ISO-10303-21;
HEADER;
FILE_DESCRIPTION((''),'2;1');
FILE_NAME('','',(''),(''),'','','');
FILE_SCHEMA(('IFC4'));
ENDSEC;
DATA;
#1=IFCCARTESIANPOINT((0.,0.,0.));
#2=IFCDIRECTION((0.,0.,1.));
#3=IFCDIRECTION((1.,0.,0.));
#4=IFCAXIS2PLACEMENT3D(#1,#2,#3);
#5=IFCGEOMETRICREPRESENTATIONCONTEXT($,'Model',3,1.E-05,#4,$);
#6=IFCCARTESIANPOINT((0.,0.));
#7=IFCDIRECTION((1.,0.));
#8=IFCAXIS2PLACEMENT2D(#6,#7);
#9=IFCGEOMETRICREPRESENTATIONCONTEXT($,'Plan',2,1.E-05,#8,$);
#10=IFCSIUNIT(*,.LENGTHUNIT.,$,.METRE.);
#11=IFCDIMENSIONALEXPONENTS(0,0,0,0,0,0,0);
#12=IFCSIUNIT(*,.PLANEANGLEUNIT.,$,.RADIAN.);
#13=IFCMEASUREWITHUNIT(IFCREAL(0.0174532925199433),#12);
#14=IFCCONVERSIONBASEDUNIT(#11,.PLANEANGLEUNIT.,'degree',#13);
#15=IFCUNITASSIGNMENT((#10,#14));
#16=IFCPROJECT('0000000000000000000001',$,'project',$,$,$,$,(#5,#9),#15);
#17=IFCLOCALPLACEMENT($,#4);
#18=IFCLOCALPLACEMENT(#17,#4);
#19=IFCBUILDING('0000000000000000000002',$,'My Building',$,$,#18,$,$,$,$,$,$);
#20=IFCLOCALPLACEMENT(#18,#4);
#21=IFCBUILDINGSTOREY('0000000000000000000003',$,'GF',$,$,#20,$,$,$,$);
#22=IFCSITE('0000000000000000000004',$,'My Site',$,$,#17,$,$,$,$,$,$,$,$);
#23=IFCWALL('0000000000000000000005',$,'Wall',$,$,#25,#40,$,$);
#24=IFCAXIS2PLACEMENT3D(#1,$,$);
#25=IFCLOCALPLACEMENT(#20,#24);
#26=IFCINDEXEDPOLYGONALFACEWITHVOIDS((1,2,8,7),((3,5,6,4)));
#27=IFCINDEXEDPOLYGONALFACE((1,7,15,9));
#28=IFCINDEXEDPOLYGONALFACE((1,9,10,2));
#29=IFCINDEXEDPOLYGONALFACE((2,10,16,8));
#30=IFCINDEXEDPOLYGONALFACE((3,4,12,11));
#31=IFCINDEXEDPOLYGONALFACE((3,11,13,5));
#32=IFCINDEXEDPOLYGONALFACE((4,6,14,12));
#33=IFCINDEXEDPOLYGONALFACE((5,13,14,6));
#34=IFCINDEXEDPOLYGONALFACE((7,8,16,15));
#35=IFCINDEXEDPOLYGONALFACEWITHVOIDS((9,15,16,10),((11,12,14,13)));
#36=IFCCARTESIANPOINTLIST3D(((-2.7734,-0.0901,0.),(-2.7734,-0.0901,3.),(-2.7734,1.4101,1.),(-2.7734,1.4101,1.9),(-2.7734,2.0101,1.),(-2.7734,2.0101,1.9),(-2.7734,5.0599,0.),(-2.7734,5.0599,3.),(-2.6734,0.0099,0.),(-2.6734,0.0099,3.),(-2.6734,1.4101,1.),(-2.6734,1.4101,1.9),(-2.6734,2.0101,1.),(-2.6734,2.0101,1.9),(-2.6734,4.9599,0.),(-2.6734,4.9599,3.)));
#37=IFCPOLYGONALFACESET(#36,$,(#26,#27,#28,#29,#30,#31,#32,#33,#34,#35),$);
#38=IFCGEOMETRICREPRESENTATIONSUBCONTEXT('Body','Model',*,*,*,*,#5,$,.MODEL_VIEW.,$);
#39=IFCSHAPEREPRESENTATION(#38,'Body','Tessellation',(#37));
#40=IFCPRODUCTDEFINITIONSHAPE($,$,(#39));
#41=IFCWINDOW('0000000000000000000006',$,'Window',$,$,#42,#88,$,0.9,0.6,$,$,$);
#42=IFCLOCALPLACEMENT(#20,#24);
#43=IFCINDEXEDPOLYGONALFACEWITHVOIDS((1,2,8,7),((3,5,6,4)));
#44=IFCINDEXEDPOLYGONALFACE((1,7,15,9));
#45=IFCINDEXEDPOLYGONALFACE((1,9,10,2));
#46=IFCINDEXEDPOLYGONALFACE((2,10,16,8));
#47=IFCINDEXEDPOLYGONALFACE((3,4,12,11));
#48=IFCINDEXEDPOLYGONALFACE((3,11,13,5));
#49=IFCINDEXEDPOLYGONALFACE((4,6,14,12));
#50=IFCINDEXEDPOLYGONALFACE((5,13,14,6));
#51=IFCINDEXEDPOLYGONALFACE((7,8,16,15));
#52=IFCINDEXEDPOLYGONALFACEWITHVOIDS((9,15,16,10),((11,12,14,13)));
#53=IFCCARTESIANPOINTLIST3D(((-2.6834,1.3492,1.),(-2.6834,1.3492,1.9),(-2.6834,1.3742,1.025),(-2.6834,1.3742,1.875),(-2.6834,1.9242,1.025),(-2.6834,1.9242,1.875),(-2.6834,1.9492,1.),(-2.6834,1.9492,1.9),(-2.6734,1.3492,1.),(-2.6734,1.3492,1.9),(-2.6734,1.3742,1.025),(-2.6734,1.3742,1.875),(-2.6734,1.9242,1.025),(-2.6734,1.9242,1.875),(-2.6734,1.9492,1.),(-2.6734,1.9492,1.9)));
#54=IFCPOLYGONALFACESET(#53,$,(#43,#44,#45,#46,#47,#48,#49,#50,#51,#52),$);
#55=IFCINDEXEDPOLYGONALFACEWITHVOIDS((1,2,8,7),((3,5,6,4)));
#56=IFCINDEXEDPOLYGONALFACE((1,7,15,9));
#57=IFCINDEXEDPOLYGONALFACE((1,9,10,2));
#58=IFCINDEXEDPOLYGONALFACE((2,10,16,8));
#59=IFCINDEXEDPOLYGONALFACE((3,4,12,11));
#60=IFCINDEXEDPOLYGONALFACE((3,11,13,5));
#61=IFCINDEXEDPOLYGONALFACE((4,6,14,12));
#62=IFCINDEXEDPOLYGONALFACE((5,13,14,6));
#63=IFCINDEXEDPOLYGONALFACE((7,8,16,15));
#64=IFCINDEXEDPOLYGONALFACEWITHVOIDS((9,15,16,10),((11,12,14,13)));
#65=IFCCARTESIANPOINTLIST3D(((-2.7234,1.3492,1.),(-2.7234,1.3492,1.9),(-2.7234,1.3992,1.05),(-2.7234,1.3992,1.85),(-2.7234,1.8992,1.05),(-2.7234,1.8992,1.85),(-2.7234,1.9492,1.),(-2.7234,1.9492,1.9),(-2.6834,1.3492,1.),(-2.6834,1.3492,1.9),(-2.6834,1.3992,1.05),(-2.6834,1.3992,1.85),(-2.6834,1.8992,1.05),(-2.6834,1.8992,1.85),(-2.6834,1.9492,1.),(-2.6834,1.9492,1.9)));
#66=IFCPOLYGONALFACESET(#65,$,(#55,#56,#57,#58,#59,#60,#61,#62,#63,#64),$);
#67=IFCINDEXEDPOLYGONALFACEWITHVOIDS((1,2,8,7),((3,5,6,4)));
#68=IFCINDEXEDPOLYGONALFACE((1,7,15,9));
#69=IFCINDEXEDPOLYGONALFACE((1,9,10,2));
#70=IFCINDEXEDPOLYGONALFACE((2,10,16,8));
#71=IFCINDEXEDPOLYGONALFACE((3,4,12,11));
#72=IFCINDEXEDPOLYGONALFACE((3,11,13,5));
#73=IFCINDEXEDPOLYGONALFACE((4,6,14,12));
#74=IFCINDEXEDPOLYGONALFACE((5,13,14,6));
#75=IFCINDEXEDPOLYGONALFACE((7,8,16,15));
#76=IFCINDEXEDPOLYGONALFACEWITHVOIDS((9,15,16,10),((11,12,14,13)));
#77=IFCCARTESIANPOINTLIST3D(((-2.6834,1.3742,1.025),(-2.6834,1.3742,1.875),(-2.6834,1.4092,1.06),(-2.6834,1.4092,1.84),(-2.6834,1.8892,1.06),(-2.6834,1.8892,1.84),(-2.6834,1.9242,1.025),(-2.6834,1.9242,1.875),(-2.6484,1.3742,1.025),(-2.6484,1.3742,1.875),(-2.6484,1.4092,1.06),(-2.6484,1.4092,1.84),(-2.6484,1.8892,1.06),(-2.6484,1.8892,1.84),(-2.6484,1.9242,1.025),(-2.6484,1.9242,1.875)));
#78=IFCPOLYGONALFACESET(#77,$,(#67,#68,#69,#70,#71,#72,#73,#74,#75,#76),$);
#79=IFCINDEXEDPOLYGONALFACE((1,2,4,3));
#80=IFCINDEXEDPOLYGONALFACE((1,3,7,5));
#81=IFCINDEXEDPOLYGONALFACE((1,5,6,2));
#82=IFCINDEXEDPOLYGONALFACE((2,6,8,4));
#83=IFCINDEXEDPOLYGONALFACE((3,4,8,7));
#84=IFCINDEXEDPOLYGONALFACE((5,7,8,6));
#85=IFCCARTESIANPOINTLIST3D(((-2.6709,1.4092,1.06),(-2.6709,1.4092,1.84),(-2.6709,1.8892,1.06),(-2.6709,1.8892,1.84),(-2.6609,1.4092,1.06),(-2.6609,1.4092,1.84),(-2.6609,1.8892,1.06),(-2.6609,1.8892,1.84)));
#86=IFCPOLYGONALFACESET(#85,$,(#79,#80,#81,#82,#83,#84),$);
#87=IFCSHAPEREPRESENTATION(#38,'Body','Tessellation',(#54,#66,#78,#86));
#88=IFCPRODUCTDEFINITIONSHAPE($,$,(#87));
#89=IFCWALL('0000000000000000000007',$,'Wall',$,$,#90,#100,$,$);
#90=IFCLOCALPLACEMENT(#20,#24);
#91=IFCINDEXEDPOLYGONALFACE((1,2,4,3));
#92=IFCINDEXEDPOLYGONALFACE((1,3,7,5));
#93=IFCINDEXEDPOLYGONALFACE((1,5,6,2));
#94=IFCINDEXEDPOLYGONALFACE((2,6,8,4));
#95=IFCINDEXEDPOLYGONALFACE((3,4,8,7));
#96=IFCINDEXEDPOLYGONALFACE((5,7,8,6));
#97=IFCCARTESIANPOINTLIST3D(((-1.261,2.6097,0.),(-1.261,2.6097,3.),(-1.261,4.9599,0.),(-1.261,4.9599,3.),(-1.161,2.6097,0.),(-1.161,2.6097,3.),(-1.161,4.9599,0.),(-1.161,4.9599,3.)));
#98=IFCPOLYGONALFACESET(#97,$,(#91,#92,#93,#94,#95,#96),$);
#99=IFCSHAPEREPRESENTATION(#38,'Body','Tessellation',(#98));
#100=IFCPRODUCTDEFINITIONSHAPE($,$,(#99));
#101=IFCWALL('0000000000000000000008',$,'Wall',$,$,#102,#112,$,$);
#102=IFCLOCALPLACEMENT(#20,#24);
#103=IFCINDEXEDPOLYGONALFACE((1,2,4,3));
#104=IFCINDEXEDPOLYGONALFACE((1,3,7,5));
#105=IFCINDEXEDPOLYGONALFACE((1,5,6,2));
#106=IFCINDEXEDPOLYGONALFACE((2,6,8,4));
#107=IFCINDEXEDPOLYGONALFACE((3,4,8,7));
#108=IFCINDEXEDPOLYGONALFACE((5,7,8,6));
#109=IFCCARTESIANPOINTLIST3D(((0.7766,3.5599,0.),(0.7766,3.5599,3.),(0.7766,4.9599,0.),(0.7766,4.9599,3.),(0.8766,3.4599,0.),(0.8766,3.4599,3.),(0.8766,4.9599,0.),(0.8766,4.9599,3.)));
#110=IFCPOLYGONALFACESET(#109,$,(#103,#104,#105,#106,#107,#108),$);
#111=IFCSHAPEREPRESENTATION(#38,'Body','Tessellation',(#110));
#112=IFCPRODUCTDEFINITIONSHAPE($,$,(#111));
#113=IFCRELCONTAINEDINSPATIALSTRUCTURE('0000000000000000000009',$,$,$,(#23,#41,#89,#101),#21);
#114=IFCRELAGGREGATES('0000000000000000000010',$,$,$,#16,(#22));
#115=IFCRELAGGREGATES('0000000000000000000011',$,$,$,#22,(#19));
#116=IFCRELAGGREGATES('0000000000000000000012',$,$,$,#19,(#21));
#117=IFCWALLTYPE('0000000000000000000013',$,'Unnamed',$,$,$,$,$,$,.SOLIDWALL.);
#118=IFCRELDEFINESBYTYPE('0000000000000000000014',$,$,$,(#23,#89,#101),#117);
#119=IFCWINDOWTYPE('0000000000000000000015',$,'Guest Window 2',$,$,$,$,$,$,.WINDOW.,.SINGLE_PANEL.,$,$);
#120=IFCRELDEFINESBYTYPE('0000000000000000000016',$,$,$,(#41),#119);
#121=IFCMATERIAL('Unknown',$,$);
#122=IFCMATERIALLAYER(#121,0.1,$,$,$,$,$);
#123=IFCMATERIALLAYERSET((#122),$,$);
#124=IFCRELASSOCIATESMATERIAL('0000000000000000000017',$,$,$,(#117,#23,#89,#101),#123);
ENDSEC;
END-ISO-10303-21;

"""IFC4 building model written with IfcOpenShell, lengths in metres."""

from ifc_helpers import new_model, entity, si_unit, converted_unit, frame, origin_with_axes, origin_2d_with_axis, place, context, subcontext, project, spatial, line, indexed_curve, outline, extrude, shape, source, transform, mapped, material, layer, layer_set, layer_usage, type_object, type_shapes, element, fill, save


model = new_model("IFC4")

# Units and contexts
model_context = context("Model", 3, precision=1e-05, world=origin_with_axes())
plan_context = context("Plan", 2, precision=1e-05, world=origin_2d_with_axis())
body_context_1 = subcontext(model_context, "Body", "Model", "MODEL_VIEW")
body_context_2 = subcontext(plan_context, "Body", "Plan", "PLAN_VIEW")
ifc_project = project(units=[si_unit("LENGTHUNIT", "METRE"), converted_unit("PLANEANGLEUNIT", "degree", entity("IfcReal", 0.0174532925199433), si_unit("PLANEANGLEUNIT", "RADIAN"), dimensions=[0, 0, 0, 0, 0, 0, 0])], contexts=[model_context, plan_context])

# Site, building, storey
site_placement = place(None, origin_with_axes())
site = spatial("IfcSite", under=ifc_project, at=site_placement, Name="My Site")
building_placement = place(site_placement, origin_with_axes())
building = spatial("IfcBuilding", under=site, at=building_placement, Name="My Building")
storey_placement = place(building_placement, origin_with_axes())
storey = spatial("IfcBuildingStorey", under=building, at=storey_placement, Name="GF")

# Shared definitions
ifc_material_1 = material(Name="Unknown")

# Shared definitions
ifc_layer_1 = layer(ifc_material_1, 0.1)
ifc_layer_set_1 = layer_set([ifc_layer_1])
wall_type = type_object("IfcWallType", Name="Unnamed", PredefinedType="SOLIDWALL", material=ifc_layer_set_1)

# Wall, opening, window
ifc_layer_usage_1 = layer_usage(ifc_layer_set_1, "AXIS2", "POSITIVE", 0.0)
wall_1_placement = place(storey_placement, frame((-2.7734, 5.0599, 0.0), z_axis=(0.0, 0.0, 1.0), x_axis=(0.0, -1.0, 0.0)))
wall_1 = element("IfcWall", 1, at=wall_1_placement, inside=storey, type_object=wall_type, material=ifc_layer_usage_1, Name="Wall", context=body_context_1, shape_type="SweptSolid", body=[
    extrude(outline(indexed_curve([(0.0, 0.0), (0.1, 0.1), (5.05, 0.1), (5.15, 0.0)], segments=[line(1, 2, 3, 4, 1)])), origin_with_axes(), (0.0, 0.0, 1.0), 3.0),
])
shared_shape_1 = source(origin_with_axes(), body_context_1, "Body", "SweptSolid", [
    extrude(outline(indexed_curve([(0.0, 0.0), (0.6, 0.0), (0.6, 0.9), (0.0, 0.9)], segments=[line(1, 2, 3, 4, 1)])), frame((0.0, -0.6, 0.0), z_axis=(0.0, -1.0, 0.0), x_axis=(1.0, 0.0, 0.0)), (0.0, 0.0, -1.0), 1.2),
])
opening_1_placement = place(wall_1_placement, frame((3.0498, 0.0, 1.0), z_axis=(0.0, 0.0, 1.0), x_axis=(1.0, 0.0, 0.0)))
opening_1 = element("IfcOpeningElement", 2, at=opening_1_placement, cuts=wall_1, PredefinedType="OPENING", context=body_context_1, shape_type="MappedRepresentation", body=[
    mapped(shared_shape_1, transform((0.0, 0.0, 0.0), x_axis=(1.0, 0.0, 0.0), y_axis=(0.0, 1.0, 0.0), z_axis=(0.0, 0.0, 1.0), scale=1.0)),
])
window_type_1 = type_object("IfcWindowType", Name="Guest Window 2", PartitioningType="SINGLE_PANEL", PredefinedType="WINDOW")
shared_shape_2 = source(origin_with_axes(), body_context_1, "Body", "SweptSolid", [
    extrude(outline(indexed_curve([(0.0, 0.0), (0.6, 0.0), (0.6, 0.9), (0.0, 0.9)], segments=[line(1, 2, 3, 4, 1)]), holes=[indexed_curve([(0.025, 0.025), (0.575, 0.025), (0.575, 0.875), (0.025, 0.875)], segments=[line(1, 2, 3, 4, 1)])]), frame((0.0, 0.09, 0.0), z_axis=(0.0, -1.0, 0.0), x_axis=(1.0, 0.0, 0.0)), (0.0, 0.0, -1.0), 0.01),
    extrude(outline(indexed_curve([(0.0, 0.0), (0.6, 0.0), (0.6, 0.9), (0.0, 0.9)], segments=[line(1, 2, 3, 4, 1)]), holes=[indexed_curve([(0.05, 0.05), (0.55, 0.05), (0.55, 0.85), (0.05, 0.85)], segments=[line(1, 2, 3, 4, 1)])]), frame((0.0, 0.05, 0.0), z_axis=(0.0, -1.0, 0.0), x_axis=(1.0, 0.0, 0.0)), (0.0, 0.0, -1.0), 0.04),
    extrude(outline(indexed_curve([(0.0, 0.0), (0.55, 0.0), (0.55, 0.85), (0.0, 0.85)], segments=[line(1, 2, 3, 4, 1)]), holes=[indexed_curve([(0.035, 0.035), (0.515, 0.035), (0.515, 0.815), (0.035, 0.815)], segments=[line(1, 2, 3, 4, 1)])]), frame((0.025, 0.09, 0.025), z_axis=(0.0, -1.0, 0.0), x_axis=(1.0, 0.0, 0.0)), (0.0, 0.0, -1.0), 0.035),
    extrude(outline(indexed_curve([(0.035, 0.035), (0.515, 0.035), (0.515, 0.815), (0.035, 0.815)], segments=[line(1, 2, 3, 4, 1)])), frame((0.025, 0.1025, 0.025), z_axis=(0.0, -1.0, 0.0), x_axis=(1.0, 0.0, 0.0)), (0.0, 0.0, -1.0), 0.01),
])
shared_shape_3 = source(origin_with_axes(), body_context_2, "Body", "Curve2D", [
    entity("IfcIndexedPolyCurve", entity("IfcCartesianPointList2D", [[0.05, 0.05], [0.55, 0.05]])),
    entity("IfcIndexedPolyCurve", entity("IfcCartesianPointList2D", [[0.0, 0.1], [0.025, 0.1], [0.025, 0.09], [0.05, 0.09], [0.05, 0.05], [0.0, 0.05]]), [entity("IfcLineIndex", [1, 2, 3, 4, 5, 6, 1])]),
    entity("IfcIndexedPolyCurve", entity("IfcCartesianPointList2D", [[0.6, 0.1], [0.575, 0.1], [0.575, 0.09], [0.55, 0.09], [0.55, 0.05], [0.6, 0.05]]), [entity("IfcLineIndex", [1, 2, 3, 4, 5, 6, 1])]),
    entity("IfcIndexedPolyCurve", entity("IfcCartesianPointList2D", [[0.025, 0.09], [0.06, 0.09], [0.06, 0.125], [0.025, 0.125]]), [entity("IfcLineIndex", [1, 2, 3, 4, 1])]),
    entity("IfcIndexedPolyCurve", entity("IfcCartesianPointList2D", [[0.575, 0.09], [0.54, 0.09], [0.54, 0.125], [0.575, 0.125]]), [entity("IfcLineIndex", [1, 2, 3, 4, 1])]),
    entity("IfcIndexedPolyCurve", entity("IfcCartesianPointList2D", [[0.06, 0.09], [0.54, 0.09]])),
    entity("IfcIndexedPolyCurve", entity("IfcCartesianPointList2D", [[0.06, 0.125], [0.54, 0.125]])),
    entity("IfcIndexedPolyCurve", entity("IfcCartesianPointList2D", [[0.06, 0.1075], [0.54, 0.1075]])),
])
type_shapes(window_type_1, [shared_shape_2, shared_shape_3])
window_1_placement = place(opening_1_placement, frame((0.061, 0.0, 0.0), z_axis=(0.0, 0.0, 1.0), x_axis=(1.0, 0.0, 0.0)))
window_1 = element("IfcWindow", 3, at=window_1_placement, inside=storey, type_object=window_type_1, Name="Window", OverallHeight=0.9, OverallWidth=0.6, shapes=[
    shape(body_context_1, "Body", "MappedRepresentation", [mapped(shared_shape_2, transform((0.0, 0.0, 0.0), x_axis=(1.0, 0.0, 0.0), y_axis=(0.0, 1.0, 0.0), z_axis=(0.0, 0.0, 1.0), scale=1.0))]),
    shape(body_context_2, "Body", "MappedRepresentation", [mapped(shared_shape_3, transform((0.0, 0.0, 0.0), x_axis=(1.0, 0.0, 0.0), y_axis=(0.0, 1.0, 0.0), z_axis=(0.0, 0.0, 1.0), scale=1.0))]),
])
fill(opening_1, window_1)

# Walls
ifc_layer_usage_2 = layer_usage(ifc_layer_set_1, "AXIS2", "POSITIVE", 0.0)
wall_2_placement = place(storey_placement, frame((-1.261, 4.9599, 0.0), z_axis=(0.0, 0.0, 1.0), x_axis=(0.000037, -1.0, 0.0)))
element("IfcWall", 4, at=wall_2_placement, inside=storey, type_object=wall_type, material=ifc_layer_usage_2, Name="Wall", context=body_context_1, shape_type="SweptSolid", body=[
    extrude(outline(indexed_curve([(0.0, 0.0), (0.0, 0.1), (2.3502, 0.1), (2.3502, 0.0)], segments=[line(1, 2, 3, 4, 1)])), origin_with_axes(), (0.0, 0.0, 1.0), 3.0),
])
ifc_layer_usage_3 = layer_usage(ifc_layer_set_1, "AXIS2", "POSITIVE", 0.0)
wall_3_placement = place(storey_placement, frame((0.7766, 4.9599, 0.0), z_axis=(0.0, 0.0, 1.0), x_axis=(0.0, -1.0, 0.0)))
element("IfcWall", 5, at=wall_3_placement, inside=storey, type_object=wall_type, material=ifc_layer_usage_3, Name="Wall", context=body_context_1, shape_type="SweptSolid", body=[
    extrude(outline(indexed_curve([(0.0, 0.0), (0.0, 0.1), (1.5, 0.1), (1.4, 0.0)], segments=[line(1, 2, 3, 4, 1)])), origin_with_axes(), (0.0, 0.0, 1.0), 3.0),
])

save(model, "model.ifc")
